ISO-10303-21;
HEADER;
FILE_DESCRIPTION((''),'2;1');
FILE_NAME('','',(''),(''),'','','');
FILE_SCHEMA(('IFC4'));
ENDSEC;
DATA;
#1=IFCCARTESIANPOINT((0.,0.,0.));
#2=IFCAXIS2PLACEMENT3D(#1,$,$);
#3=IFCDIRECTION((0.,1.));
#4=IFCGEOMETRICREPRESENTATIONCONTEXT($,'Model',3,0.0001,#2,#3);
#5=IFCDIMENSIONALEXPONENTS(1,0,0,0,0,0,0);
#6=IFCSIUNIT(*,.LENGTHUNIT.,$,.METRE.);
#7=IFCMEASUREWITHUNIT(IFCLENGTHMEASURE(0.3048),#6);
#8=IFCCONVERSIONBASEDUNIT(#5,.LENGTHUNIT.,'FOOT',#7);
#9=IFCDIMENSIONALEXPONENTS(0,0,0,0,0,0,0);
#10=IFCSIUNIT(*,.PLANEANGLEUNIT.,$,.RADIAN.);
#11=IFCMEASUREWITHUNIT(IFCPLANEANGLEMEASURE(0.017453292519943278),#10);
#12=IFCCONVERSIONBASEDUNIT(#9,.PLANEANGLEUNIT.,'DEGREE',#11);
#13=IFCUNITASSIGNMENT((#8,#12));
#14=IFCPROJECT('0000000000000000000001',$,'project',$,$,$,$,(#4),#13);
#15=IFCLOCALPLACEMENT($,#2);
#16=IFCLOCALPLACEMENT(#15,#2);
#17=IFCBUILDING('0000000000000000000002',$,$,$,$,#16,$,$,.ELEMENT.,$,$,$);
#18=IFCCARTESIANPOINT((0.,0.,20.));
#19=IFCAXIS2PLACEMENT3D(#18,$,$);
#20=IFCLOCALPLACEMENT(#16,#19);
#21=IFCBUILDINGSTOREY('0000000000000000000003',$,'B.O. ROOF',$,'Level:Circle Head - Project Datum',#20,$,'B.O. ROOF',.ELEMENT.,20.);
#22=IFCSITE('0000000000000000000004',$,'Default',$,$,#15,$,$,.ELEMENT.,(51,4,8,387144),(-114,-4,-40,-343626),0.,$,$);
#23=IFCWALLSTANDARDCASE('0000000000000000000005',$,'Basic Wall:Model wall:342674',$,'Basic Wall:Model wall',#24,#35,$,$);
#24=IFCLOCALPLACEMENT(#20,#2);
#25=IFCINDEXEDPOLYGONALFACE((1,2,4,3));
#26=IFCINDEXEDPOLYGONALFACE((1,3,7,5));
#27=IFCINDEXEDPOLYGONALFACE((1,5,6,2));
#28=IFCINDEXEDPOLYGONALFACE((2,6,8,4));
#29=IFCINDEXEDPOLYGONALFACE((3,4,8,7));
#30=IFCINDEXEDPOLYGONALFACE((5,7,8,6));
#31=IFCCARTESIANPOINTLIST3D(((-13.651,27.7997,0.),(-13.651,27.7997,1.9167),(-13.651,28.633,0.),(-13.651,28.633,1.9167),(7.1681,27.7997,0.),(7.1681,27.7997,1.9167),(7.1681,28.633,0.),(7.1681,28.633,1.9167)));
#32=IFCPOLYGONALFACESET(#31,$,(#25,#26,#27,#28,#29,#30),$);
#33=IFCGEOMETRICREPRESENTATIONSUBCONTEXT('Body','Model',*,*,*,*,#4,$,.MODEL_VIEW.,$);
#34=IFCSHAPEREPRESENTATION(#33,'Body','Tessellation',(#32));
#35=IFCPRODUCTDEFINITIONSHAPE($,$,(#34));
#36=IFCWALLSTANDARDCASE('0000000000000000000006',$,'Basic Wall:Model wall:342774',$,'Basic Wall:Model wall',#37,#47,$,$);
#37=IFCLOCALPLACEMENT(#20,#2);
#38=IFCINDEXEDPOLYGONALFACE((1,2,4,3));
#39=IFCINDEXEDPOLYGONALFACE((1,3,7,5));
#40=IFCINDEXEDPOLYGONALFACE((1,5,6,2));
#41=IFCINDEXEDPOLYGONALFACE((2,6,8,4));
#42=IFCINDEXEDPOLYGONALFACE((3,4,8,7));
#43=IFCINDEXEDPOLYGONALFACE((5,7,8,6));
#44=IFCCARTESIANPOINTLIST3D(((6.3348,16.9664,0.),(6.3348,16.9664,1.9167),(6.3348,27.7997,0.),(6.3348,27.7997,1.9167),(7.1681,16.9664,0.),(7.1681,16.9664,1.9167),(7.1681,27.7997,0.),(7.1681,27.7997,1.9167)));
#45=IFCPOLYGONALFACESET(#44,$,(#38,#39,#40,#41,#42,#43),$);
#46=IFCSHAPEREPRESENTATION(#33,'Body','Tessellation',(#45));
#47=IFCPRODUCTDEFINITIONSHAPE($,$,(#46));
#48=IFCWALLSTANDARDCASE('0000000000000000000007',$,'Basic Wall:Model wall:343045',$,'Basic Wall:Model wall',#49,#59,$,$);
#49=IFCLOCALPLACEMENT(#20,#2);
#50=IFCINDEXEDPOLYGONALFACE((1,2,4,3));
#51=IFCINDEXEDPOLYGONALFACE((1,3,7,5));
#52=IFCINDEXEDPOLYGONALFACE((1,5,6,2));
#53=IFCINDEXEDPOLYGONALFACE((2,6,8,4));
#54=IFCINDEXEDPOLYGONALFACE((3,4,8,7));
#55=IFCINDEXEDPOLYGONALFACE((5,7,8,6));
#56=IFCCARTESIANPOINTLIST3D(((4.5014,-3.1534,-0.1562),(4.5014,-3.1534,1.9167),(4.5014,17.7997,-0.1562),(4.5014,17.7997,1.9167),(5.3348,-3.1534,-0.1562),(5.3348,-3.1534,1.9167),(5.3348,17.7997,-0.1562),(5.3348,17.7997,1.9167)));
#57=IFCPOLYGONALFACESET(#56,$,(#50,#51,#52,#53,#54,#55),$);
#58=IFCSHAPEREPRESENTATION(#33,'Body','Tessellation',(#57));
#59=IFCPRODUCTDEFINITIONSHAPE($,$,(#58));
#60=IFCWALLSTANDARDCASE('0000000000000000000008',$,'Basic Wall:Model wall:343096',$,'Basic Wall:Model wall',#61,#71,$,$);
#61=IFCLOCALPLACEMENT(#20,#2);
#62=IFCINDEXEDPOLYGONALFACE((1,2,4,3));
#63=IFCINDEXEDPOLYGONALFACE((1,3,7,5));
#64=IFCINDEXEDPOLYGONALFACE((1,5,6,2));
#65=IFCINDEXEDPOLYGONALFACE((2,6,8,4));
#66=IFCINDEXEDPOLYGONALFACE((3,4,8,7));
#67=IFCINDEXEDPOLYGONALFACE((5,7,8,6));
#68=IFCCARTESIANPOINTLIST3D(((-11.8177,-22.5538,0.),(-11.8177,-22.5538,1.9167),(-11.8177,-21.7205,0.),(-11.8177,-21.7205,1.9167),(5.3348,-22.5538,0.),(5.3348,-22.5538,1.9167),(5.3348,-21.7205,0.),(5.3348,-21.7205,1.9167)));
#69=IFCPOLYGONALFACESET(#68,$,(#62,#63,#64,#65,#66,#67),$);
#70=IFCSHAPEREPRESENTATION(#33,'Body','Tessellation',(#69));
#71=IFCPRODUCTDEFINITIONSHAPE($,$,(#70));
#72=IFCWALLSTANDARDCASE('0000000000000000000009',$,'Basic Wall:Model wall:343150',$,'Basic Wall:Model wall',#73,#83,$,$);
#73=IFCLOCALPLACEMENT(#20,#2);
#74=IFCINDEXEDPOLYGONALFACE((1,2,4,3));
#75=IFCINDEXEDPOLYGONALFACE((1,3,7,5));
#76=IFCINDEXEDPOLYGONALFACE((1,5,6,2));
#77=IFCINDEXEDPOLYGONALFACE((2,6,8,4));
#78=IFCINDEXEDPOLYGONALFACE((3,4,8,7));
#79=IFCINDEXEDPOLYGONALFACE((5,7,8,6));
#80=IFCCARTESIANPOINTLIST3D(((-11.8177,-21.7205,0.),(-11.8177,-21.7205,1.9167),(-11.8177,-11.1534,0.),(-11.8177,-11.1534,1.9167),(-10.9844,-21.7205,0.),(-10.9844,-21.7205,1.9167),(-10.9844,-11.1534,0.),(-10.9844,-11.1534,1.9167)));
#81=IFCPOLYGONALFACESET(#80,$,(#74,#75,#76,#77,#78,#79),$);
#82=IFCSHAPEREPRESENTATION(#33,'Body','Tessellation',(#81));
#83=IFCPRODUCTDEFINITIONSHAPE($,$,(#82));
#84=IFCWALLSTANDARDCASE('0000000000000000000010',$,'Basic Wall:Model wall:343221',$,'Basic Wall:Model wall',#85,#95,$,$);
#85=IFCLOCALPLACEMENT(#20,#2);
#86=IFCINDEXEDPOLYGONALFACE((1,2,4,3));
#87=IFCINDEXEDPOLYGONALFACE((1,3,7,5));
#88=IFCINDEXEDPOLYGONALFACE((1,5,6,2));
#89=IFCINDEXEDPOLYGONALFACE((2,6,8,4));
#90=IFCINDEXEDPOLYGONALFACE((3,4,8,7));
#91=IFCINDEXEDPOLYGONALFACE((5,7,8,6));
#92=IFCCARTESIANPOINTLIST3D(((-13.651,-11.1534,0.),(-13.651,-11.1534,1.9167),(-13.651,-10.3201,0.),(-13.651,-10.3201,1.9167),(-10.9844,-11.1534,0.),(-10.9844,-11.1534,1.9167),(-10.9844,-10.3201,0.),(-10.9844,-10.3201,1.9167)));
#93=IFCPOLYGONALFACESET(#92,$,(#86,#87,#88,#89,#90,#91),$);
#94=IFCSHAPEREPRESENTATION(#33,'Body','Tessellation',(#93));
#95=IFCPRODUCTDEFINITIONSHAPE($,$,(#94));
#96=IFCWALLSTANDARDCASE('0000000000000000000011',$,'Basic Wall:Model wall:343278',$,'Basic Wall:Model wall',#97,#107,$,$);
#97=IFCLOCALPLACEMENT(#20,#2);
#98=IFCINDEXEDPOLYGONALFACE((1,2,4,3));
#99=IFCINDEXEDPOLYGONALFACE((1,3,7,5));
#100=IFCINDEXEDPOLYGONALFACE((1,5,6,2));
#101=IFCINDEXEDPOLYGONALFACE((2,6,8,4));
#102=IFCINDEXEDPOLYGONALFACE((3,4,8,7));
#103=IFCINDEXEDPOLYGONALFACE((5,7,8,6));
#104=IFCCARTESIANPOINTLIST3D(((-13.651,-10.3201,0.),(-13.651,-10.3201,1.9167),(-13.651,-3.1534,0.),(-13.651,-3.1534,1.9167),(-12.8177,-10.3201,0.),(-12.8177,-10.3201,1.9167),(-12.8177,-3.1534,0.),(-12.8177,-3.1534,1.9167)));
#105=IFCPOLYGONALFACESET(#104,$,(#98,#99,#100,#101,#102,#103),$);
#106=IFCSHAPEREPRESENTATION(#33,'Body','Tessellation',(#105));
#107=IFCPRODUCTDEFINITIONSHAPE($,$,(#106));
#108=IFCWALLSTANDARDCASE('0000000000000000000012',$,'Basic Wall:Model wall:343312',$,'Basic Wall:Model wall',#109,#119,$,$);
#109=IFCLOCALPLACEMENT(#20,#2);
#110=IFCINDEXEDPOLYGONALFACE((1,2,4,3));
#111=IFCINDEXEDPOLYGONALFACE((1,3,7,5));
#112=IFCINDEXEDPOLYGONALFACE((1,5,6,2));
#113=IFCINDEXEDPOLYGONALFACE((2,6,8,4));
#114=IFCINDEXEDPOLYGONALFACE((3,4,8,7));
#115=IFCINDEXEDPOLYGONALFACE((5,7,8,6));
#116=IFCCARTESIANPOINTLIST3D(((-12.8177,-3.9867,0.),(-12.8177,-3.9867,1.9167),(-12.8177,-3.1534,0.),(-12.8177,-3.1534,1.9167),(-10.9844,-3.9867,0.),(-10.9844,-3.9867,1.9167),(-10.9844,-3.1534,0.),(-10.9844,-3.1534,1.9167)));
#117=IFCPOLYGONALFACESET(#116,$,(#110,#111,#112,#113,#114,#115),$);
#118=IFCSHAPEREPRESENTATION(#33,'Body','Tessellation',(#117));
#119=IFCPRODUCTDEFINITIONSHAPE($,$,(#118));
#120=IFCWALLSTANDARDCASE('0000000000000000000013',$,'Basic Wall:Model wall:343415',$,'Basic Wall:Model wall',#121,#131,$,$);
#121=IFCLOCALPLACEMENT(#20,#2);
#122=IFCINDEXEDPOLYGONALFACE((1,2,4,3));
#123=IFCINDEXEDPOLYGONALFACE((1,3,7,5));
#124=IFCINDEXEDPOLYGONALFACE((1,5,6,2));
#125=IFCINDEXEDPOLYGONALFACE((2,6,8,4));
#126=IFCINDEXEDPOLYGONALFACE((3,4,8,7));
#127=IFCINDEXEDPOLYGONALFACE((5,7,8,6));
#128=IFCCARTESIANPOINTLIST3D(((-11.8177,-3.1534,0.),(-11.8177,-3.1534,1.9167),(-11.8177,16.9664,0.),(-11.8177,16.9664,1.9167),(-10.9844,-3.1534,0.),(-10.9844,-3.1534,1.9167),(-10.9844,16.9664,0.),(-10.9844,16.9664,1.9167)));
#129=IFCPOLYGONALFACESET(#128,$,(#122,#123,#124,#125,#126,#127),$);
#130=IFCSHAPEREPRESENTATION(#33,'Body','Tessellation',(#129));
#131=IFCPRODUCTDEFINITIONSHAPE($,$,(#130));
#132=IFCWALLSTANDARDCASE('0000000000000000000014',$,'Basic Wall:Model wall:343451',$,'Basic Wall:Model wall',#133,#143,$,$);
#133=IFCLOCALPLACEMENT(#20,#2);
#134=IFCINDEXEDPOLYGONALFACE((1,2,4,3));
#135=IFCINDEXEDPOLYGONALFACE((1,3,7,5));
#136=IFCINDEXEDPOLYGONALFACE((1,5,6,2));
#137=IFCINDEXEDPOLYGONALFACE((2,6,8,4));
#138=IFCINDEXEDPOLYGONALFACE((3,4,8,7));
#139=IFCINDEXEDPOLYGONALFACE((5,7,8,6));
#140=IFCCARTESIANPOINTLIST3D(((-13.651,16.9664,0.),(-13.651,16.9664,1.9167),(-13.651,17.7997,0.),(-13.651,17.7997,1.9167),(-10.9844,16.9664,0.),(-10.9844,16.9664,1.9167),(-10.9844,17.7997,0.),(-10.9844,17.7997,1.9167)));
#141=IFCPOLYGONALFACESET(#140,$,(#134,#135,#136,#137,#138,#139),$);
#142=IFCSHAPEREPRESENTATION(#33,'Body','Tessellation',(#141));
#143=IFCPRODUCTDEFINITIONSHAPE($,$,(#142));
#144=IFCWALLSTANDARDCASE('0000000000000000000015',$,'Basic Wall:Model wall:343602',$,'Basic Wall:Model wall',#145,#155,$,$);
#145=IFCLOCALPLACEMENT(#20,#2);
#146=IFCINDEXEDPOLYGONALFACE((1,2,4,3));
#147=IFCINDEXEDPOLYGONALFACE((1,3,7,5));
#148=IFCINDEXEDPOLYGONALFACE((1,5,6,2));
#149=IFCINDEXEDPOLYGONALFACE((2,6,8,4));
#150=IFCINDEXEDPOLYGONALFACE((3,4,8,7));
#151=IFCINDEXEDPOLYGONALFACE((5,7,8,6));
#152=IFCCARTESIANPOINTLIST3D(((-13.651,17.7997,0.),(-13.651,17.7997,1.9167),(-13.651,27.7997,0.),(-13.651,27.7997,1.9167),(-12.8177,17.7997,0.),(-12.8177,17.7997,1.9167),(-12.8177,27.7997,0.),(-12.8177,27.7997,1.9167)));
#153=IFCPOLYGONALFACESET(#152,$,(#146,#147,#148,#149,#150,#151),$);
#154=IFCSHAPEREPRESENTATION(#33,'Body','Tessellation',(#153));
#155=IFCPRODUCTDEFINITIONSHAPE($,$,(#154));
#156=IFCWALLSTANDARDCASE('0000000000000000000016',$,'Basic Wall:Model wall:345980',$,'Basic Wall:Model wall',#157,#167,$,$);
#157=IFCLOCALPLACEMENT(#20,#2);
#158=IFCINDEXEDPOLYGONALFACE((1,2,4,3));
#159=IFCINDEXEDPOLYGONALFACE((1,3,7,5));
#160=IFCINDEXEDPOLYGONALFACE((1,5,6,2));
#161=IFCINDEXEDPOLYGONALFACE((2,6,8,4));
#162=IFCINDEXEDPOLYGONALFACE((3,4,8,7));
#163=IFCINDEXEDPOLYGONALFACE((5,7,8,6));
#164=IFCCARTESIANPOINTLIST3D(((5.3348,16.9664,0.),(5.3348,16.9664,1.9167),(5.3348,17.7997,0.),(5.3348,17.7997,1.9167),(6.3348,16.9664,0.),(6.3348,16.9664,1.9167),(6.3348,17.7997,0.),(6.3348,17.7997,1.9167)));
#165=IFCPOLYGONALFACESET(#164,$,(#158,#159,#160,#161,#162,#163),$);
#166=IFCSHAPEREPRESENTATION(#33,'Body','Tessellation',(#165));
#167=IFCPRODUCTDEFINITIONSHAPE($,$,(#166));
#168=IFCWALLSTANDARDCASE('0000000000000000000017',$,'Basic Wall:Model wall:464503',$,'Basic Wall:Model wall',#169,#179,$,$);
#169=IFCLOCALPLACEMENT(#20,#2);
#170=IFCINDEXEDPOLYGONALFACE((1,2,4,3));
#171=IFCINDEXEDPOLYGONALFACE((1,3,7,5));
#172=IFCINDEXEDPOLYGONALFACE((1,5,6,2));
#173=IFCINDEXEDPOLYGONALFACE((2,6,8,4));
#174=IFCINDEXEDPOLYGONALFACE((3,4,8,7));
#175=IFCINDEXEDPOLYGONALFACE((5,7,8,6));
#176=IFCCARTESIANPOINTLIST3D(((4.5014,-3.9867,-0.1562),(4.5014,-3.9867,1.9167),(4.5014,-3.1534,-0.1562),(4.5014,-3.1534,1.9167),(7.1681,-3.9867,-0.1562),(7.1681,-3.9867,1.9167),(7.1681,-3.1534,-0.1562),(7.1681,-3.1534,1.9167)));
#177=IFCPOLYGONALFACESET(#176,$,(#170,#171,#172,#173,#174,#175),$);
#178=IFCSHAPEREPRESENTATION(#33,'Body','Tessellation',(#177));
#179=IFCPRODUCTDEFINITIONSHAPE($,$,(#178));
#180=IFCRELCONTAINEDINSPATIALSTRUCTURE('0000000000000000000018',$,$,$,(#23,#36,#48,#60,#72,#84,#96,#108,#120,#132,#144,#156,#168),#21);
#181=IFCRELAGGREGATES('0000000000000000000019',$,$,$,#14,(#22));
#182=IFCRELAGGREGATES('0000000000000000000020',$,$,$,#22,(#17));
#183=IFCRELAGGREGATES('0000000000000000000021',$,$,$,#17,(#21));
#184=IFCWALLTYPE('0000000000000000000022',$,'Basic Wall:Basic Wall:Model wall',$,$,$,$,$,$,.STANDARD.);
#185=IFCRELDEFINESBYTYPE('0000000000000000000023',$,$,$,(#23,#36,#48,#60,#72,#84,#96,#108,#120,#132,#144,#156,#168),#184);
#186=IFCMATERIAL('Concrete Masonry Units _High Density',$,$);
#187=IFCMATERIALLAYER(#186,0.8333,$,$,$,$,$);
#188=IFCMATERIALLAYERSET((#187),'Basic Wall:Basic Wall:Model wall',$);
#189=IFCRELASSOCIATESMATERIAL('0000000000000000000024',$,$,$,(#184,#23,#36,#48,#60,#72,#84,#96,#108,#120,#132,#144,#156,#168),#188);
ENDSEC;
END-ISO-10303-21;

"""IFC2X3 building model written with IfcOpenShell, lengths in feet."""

from ifc_helpers import new_model, entity, si_unit, converted_unit, direction, frame, frame_2d, origin, place, context, subcontext, project, spatial, rectangle, extrude, material, layer, layer_set, layer_usage, type_object, element, save


model = new_model("IFC2X3")

# Units and contexts
model_context = context("Model", 3, precision=0.0001, world=origin(), true_north=direction((0.0, 1.0)))
body_context = subcontext(model_context, "Body", "Model", "MODEL_VIEW")
ifc_project = project(units=[converted_unit("LENGTHUNIT", "FOOT", entity("IfcLengthMeasure", 0.3048), si_unit("LENGTHUNIT", "METRE"), dimensions=[1, 0, 0, 0, 0, 0, 0]), converted_unit("PLANEANGLEUNIT", "DEGREE", entity("IfcPlaneAngleMeasure", 0.017453292519943278), si_unit("PLANEANGLEUNIT", "RADIAN"), dimensions=[0, 0, 0, 0, 0, 0, 0])], contexts=[model_context])

# Site, building, storey
site_placement = place(None, origin())
site = spatial("IfcSite", under=ifc_project, at=site_placement, Name="Default", CompositionType="ELEMENT", RefLatitude=(51, 4, 8, 387144), RefLongitude=(-114, -4, -40, -343626), RefElevation=0.0)
building_placement = place(site_placement, origin())
building = spatial("IfcBuilding", under=site, at=building_placement, CompositionType="ELEMENT")
storey_placement = place(building_placement, frame((0.0, 0.0, 20.0)))
storey = spatial("IfcBuildingStorey", under=building, at=storey_placement, Name="B.O. ROOF", ObjectType="Level:Circle Head - Project Datum", LongName="B.O. ROOF", CompositionType="ELEMENT", Elevation=20.0)

# Walls
ifc_material_1 = material(Name="Concrete Masonry Units _High Density")
ifc_layer = layer(ifc_material_1, 0.8333)
ifc_layer_set = layer_set([ifc_layer], Name="Basic Wall:Basic Wall:Model wall")
ifc_layer_usage_1 = layer_usage(ifc_layer_set, "AXIS2", "NEGATIVE", 0.4167)
wall_type = type_object("IfcWallType", Name="Basic Wall:Basic Wall:Model wall", PredefinedType="STANDARD", material=ifc_layer_set)
wall_1_placement = place(storey_placement, frame((-13.651, 28.2164, 0.0)))
element("IfcWallStandardCase", 1, at=wall_1_placement, inside=storey, type_object=wall_type, material=ifc_layer_usage_1, Name="Basic Wall:Model wall:342674", ObjectType="Basic Wall:Model wall", context=body_context, shape_type="SweptSolid", body=[
    extrude(rectangle(XDim=20.8192, YDim=0.8333, at=frame_2d((10.4096, 0.0), x_axis=(-1.0, 0.0))), origin(), (0.0, 0.0, 1.0), 1.9167),
])
ifc_layer_usage_2 = layer_usage(ifc_layer_set, "AXIS2", "NEGATIVE", 0.4167)
wall_2_placement = place(storey_placement, frame((6.7514, 27.7997, 0.0), z_axis=(0.0, 0.0, 1.0), x_axis=(0.0, -1.0, 0.0)))
element("IfcWallStandardCase", 2, at=wall_2_placement, inside=storey, type_object=wall_type, material=ifc_layer_usage_2, Name="Basic Wall:Model wall:342774", ObjectType="Basic Wall:Model wall", context=body_context, shape_type="SweptSolid", body=[
    extrude(rectangle(XDim=10.8333, YDim=0.8333, at=frame_2d((5.4167, 0.0), x_axis=(-1.0, 0.0))), origin(), (0.0, 0.0, 1.0), 1.9167),
])
ifc_layer_usage_3 = layer_usage(ifc_layer_set, "AXIS2", "NEGATIVE", 0.4167)
wall_3_placement = place(storey_placement, frame((4.9181, 17.7997, -0.1562), z_axis=(0.0, 0.0, 1.0), x_axis=(0.0, -1.0, 0.0)))
element("IfcWallStandardCase", 3, at=wall_3_placement, inside=storey, type_object=wall_type, material=ifc_layer_usage_3, Name="Basic Wall:Model wall:343045", ObjectType="Basic Wall:Model wall", context=body_context, shape_type="SweptSolid", body=[
    extrude(rectangle(XDim=20.9531, YDim=0.8333, at=frame_2d((10.4766, 0.0), x_axis=(-1.0, 0.0))), origin(), (0.0, 0.0, 1.0), 2.0728),
])
ifc_layer_usage_4 = layer_usage(ifc_layer_set, "AXIS2", "NEGATIVE", 0.4167)
wall_4_placement = place(storey_placement, frame((5.3348, -22.1371, 0.0), z_axis=(0.0, 0.0, 1.0), x_axis=(-1.0, 0.0, 0.0)))
element("IfcWallStandardCase", 4, at=wall_4_placement, inside=storey, type_object=wall_type, material=ifc_layer_usage_4, Name="Basic Wall:Model wall:343096", ObjectType="Basic Wall:Model wall", context=body_context, shape_type="SweptSolid", body=[
    extrude(rectangle(XDim=17.1525, YDim=0.8333, at=frame_2d((8.5762, 0.0), x_axis=(-1.0, 0.0))), origin(), (0.0, 0.0, 1.0), 1.9167),
])
ifc_layer_usage_5 = layer_usage(ifc_layer_set, "AXIS2", "NEGATIVE", 0.4167)
wall_5_placement = place(storey_placement, frame((-11.401, -21.7205, 0.0), z_axis=(0.0, 0.0, 1.0), x_axis=(0.0, 1.0, 0.0)))
element("IfcWallStandardCase", 5, at=wall_5_placement, inside=storey, type_object=wall_type, material=ifc_layer_usage_5, Name="Basic Wall:Model wall:343150", ObjectType="Basic Wall:Model wall", context=body_context, shape_type="SweptSolid", body=[
    extrude(rectangle(XDim=10.5671, YDim=0.8333, at=frame_2d((5.2835, 0.0), x_axis=(-1.0, 0.0))), origin(), (0.0, 0.0, 1.0), 1.9167),
])
ifc_layer_usage_6 = layer_usage(ifc_layer_set, "AXIS2", "NEGATIVE", 0.4167)
wall_6_placement = place(storey_placement, frame((-10.9844, -10.7367, 0.0), z_axis=(0.0, 0.0, 1.0), x_axis=(-1.0, 0.0, 0.0)))
element("IfcWallStandardCase", 6, at=wall_6_placement, inside=storey, type_object=wall_type, material=ifc_layer_usage_6, Name="Basic Wall:Model wall:343221", ObjectType="Basic Wall:Model wall", context=body_context, shape_type="SweptSolid", body=[
    extrude(rectangle(XDim=2.6667, YDim=0.8333, at=frame_2d((1.3333, 0.0), x_axis=(-1.0, 0.0))), origin(), (0.0, 0.0, 1.0), 1.9167),
])
ifc_layer_usage_7 = layer_usage(ifc_layer_set, "AXIS2", "NEGATIVE", 0.4167)
wall_7_placement = place(storey_placement, frame((-13.2344, -10.3201, 0.0), z_axis=(0.0, 0.0, 1.0), x_axis=(0.0, 1.0, 0.0)))
element("IfcWallStandardCase", 7, at=wall_7_placement, inside=storey, type_object=wall_type, material=ifc_layer_usage_7, Name="Basic Wall:Model wall:343278", ObjectType="Basic Wall:Model wall", context=body_context, shape_type="SweptSolid", body=[
    extrude(rectangle(XDim=7.1667, YDim=0.8333, at=frame_2d((3.5833, 0.0), x_axis=(-1.0, 0.0))), origin(), (0.0, 0.0, 1.0), 1.9167),
])
ifc_layer_usage_8 = layer_usage(ifc_layer_set, "AXIS2", "NEGATIVE", 0.4167)
wall_8_placement = place(storey_placement, frame((-12.8177, -3.5701, 0.0)))
element("IfcWallStandardCase", 8, at=wall_8_placement, inside=storey, type_object=wall_type, material=ifc_layer_usage_8, Name="Basic Wall:Model wall:343312", ObjectType="Basic Wall:Model wall", context=body_context, shape_type="SweptSolid", body=[
    extrude(rectangle(XDim=1.8333, YDim=0.8333, at=frame_2d((0.9167, 0.0), x_axis=(-1.0, 0.0))), origin(), (0.0, 0.0, 1.0), 1.9167),
])
ifc_layer_usage_9 = layer_usage(ifc_layer_set, "AXIS2", "NEGATIVE", 0.4167)
wall_9_placement = place(storey_placement, frame((-11.401, -3.1534, 0.0), z_axis=(0.0, 0.0, 1.0), x_axis=(0.0, 1.0, 0.0)))
element("IfcWallStandardCase", 9, at=wall_9_placement, inside=storey, type_object=wall_type, material=ifc_layer_usage_9, Name="Basic Wall:Model wall:343415", ObjectType="Basic Wall:Model wall", context=body_context, shape_type="SweptSolid", body=[
    extrude(rectangle(XDim=20.1198, YDim=0.8333, at=frame_2d((10.0599, 0.0), x_axis=(-1.0, 0.0))), origin(), (0.0, 0.0, 1.0), 1.9167),
])
ifc_layer_usage_10 = layer_usage(ifc_layer_set, "AXIS2", "NEGATIVE", 0.4167)
wall_10_placement = place(storey_placement, frame((-10.9844, 17.383, 0.0), z_axis=(0.0, 0.0, 1.0), x_axis=(-1.0, 0.0, 0.0)))
element("IfcWallStandardCase", 10, at=wall_10_placement, inside=storey, type_object=wall_type, material=ifc_layer_usage_10, Name="Basic Wall:Model wall:343451", ObjectType="Basic Wall:Model wall", context=body_context, shape_type="SweptSolid", body=[
    extrude(rectangle(XDim=2.6667, YDim=0.8333, at=frame_2d((1.3333, 0.0), x_axis=(-1.0, 0.0))), origin(), (0.0, 0.0, 1.0), 1.9167),
])
ifc_layer_usage_11 = layer_usage(ifc_layer_set, "AXIS2", "NEGATIVE", 0.4167)
wall_11_placement = place(storey_placement, frame((-13.2344, 17.7997, 0.0), z_axis=(0.0, 0.0, 1.0), x_axis=(0.0, 1.0, 0.0)))
element("IfcWallStandardCase", 11, at=wall_11_placement, inside=storey, type_object=wall_type, material=ifc_layer_usage_11, Name="Basic Wall:Model wall:343602", ObjectType="Basic Wall:Model wall", context=body_context, shape_type="SweptSolid", body=[
    extrude(rectangle(XDim=10.0, YDim=0.8333, at=frame_2d((5.0, 0.0), x_axis=(-1.0, 0.0))), origin(), (0.0, 0.0, 1.0), 1.9167),
])
ifc_layer_usage_12 = layer_usage(ifc_layer_set, "AXIS2", "NEGATIVE", 0.4167)
wall_12_placement = place(storey_placement, frame((5.3348, 17.383, 0.0)))
element("IfcWallStandardCase", 12, at=wall_12_placement, inside=storey, type_object=wall_type, material=ifc_layer_usage_12, Name="Basic Wall:Model wall:345980", ObjectType="Basic Wall:Model wall", context=body_context, shape_type="SweptSolid", body=[
    extrude(rectangle(XDim=1.0, YDim=0.8333, at=frame_2d((0.5, 0.0), x_axis=(-1.0, 0.0))), origin(), (0.0, 0.0, 1.0), 1.9167),
])
ifc_layer_usage_13 = layer_usage(ifc_layer_set, "AXIS2", "NEGATIVE", 0.4167)
wall_13_placement = place(storey_placement, frame((4.5014, -3.5701, -0.1562)))
element("IfcWallStandardCase", 13, at=wall_13_placement, inside=storey, type_object=wall_type, material=ifc_layer_usage_13, Name="Basic Wall:Model wall:464503", ObjectType="Basic Wall:Model wall", context=body_context, shape_type="SweptSolid", body=[
    extrude(rectangle(XDim=2.6667, YDim=0.8333, at=frame_2d((1.3333, 0.0), x_axis=(-1.0, 0.0))), origin(), (0.0, 0.0, 1.0), 2.0728),
])

save(model, "model.ifc")
